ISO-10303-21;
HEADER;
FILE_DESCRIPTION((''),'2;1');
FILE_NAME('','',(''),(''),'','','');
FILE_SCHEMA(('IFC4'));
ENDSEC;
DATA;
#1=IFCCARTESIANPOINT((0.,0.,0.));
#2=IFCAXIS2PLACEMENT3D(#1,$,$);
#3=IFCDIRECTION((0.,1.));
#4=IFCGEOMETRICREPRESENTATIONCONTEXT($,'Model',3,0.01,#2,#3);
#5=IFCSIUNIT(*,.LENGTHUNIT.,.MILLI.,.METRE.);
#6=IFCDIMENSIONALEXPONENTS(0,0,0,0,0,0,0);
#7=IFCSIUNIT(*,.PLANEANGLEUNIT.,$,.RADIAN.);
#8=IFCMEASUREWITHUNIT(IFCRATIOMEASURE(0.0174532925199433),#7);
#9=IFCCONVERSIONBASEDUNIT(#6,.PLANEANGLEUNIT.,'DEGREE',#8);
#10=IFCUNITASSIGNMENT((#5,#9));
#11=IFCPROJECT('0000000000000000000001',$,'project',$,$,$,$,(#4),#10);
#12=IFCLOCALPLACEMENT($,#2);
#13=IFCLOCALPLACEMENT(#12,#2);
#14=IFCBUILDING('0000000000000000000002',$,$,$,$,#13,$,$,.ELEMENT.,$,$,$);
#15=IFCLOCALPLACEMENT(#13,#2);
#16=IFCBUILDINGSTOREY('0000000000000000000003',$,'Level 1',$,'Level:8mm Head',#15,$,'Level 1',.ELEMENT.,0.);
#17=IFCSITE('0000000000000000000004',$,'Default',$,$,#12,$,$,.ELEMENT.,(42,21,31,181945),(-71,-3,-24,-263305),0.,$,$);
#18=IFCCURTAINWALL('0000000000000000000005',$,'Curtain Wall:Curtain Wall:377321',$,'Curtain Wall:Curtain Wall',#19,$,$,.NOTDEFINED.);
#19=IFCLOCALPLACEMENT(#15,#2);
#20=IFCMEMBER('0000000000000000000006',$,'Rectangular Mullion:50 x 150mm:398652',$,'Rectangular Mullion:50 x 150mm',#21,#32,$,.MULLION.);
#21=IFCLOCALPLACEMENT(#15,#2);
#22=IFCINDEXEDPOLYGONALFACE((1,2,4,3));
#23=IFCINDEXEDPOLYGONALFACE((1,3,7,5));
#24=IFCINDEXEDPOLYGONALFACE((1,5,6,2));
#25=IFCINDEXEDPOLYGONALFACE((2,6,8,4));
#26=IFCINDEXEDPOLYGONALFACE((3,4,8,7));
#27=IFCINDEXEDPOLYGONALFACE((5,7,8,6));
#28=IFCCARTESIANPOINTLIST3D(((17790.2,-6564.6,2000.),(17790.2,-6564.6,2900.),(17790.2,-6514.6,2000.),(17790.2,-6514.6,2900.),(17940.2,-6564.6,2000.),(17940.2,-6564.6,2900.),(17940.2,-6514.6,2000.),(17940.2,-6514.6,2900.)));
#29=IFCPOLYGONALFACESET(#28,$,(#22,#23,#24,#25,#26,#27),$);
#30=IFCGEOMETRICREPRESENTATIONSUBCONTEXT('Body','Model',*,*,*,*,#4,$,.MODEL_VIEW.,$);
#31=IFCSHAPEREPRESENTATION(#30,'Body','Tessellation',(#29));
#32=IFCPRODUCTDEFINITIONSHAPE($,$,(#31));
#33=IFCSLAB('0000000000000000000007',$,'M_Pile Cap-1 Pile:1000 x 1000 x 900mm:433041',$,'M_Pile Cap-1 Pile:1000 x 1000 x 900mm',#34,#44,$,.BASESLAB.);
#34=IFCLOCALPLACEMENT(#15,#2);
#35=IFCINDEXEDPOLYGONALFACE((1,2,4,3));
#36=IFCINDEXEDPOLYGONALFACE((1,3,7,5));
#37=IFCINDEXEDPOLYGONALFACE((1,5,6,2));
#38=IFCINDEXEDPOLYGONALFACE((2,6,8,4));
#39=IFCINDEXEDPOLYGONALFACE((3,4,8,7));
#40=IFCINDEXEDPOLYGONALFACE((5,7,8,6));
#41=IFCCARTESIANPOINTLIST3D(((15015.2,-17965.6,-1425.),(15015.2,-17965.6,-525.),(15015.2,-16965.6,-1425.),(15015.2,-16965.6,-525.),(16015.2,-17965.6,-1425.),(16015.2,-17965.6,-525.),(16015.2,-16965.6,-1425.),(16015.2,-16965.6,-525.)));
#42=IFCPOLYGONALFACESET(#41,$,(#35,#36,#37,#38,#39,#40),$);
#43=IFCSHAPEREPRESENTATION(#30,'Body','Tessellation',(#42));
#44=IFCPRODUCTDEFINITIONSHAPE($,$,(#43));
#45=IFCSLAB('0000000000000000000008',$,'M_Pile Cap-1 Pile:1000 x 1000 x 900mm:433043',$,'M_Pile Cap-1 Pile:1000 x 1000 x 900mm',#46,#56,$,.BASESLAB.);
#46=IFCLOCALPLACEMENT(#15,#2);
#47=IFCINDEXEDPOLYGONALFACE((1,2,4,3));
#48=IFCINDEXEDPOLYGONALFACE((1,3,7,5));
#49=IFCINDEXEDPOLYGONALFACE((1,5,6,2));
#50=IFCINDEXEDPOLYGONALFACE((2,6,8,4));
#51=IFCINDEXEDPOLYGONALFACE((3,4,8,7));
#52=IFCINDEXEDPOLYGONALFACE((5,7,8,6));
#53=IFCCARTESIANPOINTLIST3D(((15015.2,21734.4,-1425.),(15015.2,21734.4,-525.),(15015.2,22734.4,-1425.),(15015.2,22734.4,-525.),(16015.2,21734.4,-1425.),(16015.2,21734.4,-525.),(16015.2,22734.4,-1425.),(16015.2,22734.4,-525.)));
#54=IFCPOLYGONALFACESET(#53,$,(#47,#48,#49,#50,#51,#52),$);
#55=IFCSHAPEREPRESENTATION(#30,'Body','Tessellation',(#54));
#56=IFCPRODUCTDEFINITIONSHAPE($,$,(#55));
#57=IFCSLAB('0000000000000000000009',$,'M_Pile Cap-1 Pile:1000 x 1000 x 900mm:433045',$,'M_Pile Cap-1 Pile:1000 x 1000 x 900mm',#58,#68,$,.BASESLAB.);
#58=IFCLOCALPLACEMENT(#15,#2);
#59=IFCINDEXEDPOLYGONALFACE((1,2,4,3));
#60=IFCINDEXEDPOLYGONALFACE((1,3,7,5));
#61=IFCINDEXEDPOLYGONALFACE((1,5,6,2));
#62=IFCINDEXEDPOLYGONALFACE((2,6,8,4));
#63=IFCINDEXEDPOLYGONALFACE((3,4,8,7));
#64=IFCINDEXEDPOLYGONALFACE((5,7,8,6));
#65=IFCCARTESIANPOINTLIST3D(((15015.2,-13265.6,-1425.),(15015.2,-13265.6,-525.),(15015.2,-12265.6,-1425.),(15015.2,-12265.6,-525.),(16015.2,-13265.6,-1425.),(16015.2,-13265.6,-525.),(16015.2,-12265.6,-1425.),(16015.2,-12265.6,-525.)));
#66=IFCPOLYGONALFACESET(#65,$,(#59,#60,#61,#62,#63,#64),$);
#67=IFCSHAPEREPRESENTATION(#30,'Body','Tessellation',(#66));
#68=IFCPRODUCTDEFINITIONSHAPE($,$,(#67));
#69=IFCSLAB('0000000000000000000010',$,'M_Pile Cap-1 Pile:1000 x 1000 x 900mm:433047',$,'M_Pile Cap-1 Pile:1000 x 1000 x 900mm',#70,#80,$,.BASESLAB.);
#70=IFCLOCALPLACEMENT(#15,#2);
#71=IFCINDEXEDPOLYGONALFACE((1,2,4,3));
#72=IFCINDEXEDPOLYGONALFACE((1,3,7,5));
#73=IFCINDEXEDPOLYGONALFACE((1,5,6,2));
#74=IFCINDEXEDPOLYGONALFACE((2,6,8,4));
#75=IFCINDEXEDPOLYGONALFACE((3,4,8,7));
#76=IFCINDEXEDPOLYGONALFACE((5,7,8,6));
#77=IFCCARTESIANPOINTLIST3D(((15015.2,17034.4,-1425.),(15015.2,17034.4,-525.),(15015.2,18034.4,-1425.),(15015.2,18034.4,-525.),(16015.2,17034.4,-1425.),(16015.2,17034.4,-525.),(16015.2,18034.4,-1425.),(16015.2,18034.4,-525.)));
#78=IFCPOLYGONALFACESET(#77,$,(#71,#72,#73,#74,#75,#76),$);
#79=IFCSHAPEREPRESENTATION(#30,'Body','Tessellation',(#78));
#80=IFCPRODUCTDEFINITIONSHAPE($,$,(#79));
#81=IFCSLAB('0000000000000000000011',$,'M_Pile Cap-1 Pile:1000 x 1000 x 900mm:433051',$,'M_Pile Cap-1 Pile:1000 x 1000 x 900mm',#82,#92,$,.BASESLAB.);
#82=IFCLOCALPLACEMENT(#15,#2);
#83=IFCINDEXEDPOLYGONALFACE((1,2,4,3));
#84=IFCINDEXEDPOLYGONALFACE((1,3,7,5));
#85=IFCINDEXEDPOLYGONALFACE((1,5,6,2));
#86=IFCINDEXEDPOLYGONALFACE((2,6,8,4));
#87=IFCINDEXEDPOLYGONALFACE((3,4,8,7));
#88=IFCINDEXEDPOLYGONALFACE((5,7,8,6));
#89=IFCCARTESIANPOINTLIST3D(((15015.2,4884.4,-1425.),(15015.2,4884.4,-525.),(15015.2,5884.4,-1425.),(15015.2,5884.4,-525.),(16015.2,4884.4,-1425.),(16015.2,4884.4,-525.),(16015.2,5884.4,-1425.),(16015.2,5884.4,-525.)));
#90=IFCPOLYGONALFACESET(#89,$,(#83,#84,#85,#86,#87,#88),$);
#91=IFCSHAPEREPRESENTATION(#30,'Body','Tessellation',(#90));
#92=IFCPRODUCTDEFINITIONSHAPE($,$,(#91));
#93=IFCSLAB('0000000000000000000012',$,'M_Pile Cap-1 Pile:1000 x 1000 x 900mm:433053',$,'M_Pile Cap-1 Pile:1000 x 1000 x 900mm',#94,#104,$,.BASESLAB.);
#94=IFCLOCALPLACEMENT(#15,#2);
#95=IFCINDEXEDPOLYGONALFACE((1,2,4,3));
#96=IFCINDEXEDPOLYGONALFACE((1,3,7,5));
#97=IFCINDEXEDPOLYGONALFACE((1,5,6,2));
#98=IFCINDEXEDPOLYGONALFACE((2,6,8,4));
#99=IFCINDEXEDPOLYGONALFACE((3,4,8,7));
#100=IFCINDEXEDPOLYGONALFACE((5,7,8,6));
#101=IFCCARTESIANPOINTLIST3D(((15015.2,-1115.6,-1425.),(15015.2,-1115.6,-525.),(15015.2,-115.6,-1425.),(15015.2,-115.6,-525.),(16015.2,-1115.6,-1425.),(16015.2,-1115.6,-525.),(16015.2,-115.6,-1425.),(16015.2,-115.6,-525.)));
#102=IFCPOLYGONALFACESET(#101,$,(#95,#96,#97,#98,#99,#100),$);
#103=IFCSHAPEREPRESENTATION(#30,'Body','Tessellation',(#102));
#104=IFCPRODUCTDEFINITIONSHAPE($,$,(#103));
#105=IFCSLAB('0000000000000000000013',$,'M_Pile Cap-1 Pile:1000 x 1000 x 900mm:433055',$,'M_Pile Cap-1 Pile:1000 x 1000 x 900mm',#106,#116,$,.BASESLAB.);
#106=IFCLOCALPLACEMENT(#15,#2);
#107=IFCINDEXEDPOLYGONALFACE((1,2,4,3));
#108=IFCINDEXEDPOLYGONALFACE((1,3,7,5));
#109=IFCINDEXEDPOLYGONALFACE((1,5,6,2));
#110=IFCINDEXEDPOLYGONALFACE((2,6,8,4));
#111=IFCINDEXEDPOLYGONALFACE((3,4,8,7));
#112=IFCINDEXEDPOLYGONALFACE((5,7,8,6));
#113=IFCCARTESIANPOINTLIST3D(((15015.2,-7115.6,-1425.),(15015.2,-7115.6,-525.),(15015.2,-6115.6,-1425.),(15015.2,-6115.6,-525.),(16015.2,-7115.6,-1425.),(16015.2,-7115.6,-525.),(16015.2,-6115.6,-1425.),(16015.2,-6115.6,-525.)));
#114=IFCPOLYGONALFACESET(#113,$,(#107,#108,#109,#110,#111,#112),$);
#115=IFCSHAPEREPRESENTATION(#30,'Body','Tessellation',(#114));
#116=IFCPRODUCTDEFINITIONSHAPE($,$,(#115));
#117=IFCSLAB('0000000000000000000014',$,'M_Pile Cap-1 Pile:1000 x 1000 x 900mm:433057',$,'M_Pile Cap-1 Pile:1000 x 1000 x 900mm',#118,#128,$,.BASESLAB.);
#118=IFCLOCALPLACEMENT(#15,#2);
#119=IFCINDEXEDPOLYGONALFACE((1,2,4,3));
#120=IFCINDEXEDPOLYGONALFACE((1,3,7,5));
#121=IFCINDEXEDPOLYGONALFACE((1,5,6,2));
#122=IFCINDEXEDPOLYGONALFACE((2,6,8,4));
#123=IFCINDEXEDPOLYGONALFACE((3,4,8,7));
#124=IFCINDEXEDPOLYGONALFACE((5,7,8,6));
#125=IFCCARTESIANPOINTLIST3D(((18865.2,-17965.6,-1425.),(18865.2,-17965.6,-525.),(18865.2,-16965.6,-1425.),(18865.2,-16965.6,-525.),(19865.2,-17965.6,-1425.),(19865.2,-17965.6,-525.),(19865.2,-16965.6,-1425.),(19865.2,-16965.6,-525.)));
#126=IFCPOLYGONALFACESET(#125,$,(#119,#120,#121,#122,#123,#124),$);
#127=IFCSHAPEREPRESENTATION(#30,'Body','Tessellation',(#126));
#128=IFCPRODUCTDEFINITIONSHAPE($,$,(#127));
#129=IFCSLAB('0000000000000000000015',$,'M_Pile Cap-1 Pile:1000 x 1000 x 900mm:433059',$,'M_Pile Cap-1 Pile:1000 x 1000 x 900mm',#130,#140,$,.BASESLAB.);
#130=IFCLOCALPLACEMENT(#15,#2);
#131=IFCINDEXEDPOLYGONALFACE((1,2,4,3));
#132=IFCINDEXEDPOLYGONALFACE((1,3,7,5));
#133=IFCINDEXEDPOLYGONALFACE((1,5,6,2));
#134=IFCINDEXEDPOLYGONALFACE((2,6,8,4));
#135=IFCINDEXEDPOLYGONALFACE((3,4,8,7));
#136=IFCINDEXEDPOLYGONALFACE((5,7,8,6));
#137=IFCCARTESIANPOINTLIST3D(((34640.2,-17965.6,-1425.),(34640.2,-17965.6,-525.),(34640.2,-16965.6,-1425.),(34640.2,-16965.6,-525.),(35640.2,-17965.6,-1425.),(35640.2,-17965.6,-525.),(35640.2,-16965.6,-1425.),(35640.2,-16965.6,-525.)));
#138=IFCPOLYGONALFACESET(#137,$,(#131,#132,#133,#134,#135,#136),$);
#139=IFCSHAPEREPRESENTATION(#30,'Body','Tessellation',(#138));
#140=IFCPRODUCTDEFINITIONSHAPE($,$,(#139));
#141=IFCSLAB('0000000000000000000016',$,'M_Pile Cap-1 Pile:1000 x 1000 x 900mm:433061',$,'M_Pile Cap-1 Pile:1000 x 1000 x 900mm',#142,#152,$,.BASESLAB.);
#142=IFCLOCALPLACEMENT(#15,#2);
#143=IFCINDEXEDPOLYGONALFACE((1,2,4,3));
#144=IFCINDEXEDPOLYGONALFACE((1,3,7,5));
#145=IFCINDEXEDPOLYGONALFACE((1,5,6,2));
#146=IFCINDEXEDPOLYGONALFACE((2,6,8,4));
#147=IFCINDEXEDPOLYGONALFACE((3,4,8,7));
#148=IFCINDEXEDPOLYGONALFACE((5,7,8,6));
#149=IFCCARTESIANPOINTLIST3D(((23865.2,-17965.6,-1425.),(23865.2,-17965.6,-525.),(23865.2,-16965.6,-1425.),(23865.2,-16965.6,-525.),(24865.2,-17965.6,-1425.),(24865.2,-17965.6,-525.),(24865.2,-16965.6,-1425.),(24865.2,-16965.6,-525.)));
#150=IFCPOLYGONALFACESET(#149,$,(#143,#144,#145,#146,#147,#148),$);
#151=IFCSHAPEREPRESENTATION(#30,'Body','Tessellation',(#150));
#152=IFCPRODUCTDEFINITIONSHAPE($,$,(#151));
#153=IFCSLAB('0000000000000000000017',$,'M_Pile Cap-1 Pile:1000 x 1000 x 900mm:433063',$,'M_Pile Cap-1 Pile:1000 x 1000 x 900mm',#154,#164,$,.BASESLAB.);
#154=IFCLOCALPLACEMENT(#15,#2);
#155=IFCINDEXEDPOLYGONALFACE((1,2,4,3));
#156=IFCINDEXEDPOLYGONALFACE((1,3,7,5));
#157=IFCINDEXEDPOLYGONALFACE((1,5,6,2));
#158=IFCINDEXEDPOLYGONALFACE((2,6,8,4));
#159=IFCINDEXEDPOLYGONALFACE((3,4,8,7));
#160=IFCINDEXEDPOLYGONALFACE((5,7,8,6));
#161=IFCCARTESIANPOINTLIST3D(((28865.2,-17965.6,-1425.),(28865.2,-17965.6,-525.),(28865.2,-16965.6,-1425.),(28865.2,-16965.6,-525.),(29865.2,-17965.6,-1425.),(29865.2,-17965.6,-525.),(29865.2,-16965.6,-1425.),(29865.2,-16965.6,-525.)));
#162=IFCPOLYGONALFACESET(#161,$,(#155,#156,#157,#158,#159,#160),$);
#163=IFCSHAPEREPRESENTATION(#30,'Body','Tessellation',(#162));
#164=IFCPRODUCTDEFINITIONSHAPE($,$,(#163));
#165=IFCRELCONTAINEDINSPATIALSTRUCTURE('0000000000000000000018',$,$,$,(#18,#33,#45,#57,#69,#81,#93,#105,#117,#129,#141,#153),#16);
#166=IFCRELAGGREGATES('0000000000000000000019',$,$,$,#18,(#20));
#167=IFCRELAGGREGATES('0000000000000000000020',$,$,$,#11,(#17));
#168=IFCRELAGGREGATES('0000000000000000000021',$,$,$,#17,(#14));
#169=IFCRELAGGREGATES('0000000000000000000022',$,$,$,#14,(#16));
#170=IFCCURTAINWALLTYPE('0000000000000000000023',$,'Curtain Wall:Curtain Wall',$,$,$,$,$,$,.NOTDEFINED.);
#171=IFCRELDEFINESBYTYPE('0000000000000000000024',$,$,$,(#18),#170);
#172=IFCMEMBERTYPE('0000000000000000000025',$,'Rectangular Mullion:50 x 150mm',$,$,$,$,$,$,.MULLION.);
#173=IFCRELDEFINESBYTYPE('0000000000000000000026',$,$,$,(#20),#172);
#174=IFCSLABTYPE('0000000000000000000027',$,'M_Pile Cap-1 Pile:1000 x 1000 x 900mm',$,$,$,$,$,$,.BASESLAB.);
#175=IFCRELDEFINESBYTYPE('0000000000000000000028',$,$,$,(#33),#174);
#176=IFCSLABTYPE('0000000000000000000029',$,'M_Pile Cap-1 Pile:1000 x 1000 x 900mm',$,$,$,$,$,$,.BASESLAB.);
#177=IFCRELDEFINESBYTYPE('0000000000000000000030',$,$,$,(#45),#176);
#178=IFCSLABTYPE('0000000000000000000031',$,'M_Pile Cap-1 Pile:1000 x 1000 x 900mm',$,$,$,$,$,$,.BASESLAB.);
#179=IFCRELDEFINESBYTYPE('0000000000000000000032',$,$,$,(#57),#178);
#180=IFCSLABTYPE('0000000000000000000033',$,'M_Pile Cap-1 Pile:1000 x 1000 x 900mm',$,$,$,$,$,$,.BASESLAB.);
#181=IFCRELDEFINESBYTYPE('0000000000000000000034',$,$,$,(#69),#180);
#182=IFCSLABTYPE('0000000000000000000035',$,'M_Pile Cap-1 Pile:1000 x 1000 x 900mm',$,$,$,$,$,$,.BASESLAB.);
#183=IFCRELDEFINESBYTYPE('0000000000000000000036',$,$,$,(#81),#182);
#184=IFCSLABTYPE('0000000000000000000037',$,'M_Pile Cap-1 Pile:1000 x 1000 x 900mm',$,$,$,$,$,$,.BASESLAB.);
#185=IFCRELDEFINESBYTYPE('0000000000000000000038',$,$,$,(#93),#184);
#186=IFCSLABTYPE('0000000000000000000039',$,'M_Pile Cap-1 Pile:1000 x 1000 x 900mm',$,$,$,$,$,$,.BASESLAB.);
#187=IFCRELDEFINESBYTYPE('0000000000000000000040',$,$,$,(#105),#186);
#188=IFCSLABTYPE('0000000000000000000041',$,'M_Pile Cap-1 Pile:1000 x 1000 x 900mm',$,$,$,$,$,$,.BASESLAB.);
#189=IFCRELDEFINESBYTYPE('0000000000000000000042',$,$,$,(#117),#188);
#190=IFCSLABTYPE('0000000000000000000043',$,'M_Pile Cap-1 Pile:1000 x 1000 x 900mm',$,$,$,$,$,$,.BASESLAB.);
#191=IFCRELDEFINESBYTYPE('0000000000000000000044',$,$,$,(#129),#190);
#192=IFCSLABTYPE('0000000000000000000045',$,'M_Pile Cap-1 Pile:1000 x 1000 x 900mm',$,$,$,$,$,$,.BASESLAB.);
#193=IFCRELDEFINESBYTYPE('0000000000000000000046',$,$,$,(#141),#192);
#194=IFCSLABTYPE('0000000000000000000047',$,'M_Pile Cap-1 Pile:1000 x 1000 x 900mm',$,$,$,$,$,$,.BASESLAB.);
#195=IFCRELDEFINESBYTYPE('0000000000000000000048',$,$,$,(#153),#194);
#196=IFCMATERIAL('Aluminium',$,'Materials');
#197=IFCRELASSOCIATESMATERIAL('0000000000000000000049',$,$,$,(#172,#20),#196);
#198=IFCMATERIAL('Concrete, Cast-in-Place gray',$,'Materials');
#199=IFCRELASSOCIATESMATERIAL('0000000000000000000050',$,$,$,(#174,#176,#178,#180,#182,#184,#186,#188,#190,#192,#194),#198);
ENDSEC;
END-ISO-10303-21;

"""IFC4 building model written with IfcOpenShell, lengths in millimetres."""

from ifc_helpers import new_model, entity, si_unit, converted_unit, direction, frame, origin, place, context, subcontext, project, spatial, indexed_curve, outline, extrude, source, transform, mapped, material, type_object, type_shapes, element, aggregate, save


model = new_model("IFC4")

# Units and contexts
model_context = context("Model", 3, precision=0.01, world=origin(), true_north=direction((0.0, 1.0)))
body_context = subcontext(model_context, "Body", "Model", "MODEL_VIEW")
ifc_project = project(units=[si_unit("LENGTHUNIT", "METRE", prefix="MILLI"), converted_unit("PLANEANGLEUNIT", "DEGREE", entity("IfcRatioMeasure", 0.0174532925199433), si_unit("PLANEANGLEUNIT", "RADIAN"), dimensions=[0, 0, 0, 0, 0, 0, 0])], contexts=[model_context])

# Site, building, storey
site_placement = place(None, origin())
site = spatial("IfcSite", under=ifc_project, at=site_placement, Name="Default", CompositionType="ELEMENT", RefLatitude=(42, 21, 31, 181945), RefLongitude=(-71, -3, -24, -263305), RefElevation=0.0)
building_placement = place(site_placement, origin())
building = spatial("IfcBuilding", under=site, at=building_placement, CompositionType="ELEMENT")
storey_placement = place(building_placement, origin())
storey = spatial("IfcBuildingStorey", under=building, at=storey_placement, Name="Level 1", ObjectType="Level:8mm Head", LongName="Level 1", CompositionType="ELEMENT", Elevation=0.0)

# Curtain wall, member
curtain_wall_type = type_object("IfcCurtainWallType", Name="Curtain Wall:Curtain Wall", PredefinedType="NOTDEFINED")
curtain_wall_placement = place(storey_placement, origin())
curtain_wall = element("IfcCurtainWall", 1, at=curtain_wall_placement, inside=storey, type_object=curtain_wall_type, Name="Curtain Wall:Curtain Wall:377321", ObjectType="Curtain Wall:Curtain Wall", PredefinedType="NOTDEFINED")
ifc_material_1 = material(Name="Aluminium", Category="Materials")
member_type = type_object("IfcMemberType", Name="Rectangular Mullion:50 x 150mm", PredefinedType="MULLION", material=ifc_material_1)
shared_shape = source(origin(), body_context, "Body", "SweptSolid", [
    extrude(outline(indexed_curve([(-75.0, -25.0), (75.0, -25.0), (75.0, 25.0), (-75.0, 25.0), (-75.0, -25.0)], self_intersect=False)), frame((-25.0, 0.0, -900.0), z_axis=(0.0, 0.0, 1.0), x_axis=(0.0, -1.0, 0.0)), (0.0, 0.0, 1.0), 900.0),
])
type_shapes(member_type, [shared_shape])
member_placement = place(storey_placement, frame((17865.2, -6564.6, 2900.0), z_axis=(0.0, 0.0, 1.0), x_axis=(0.0, -1.0, 0.0)))
member = element("IfcMember", 2, at=member_placement, type_object=member_type, material=ifc_material_1, Name="Rectangular Mullion:50 x 150mm:398652", ObjectType="Rectangular Mullion:50 x 150mm", PredefinedType="MULLION", context=body_context, shape_type="MappedRepresentation", body=[
    mapped(shared_shape, transform((0.0, 0.0, 0.0), scale=1.0)),
])
aggregate(curtain_wall, [member])

# Slabs
ifc_material_2 = material(Name="Concrete, Cast-in-Place gray", Category="Materials")
slab_type_1 = type_object("IfcSlabType", Name="M_Pile Cap-1 Pile:1000 x 1000 x 900mm", PredefinedType="BASESLAB", material=ifc_material_2)
slab_1_placement = place(building_placement, origin())
element("IfcSlab", 3, at=slab_1_placement, inside=storey, type_object=slab_type_1, Name="M_Pile Cap-1 Pile:1000 x 1000 x 900mm:433041", ObjectType="M_Pile Cap-1 Pile:1000 x 1000 x 900mm", PredefinedType="BASESLAB", context=body_context, shape_type="SweptSolid", body=[
    extrude(outline(indexed_curve([(-500.0, -500.0), (500.0, -500.0), (500.0, 500.0), (-500.0, 500.0), (-500.0, -500.0)], self_intersect=False)), frame((15515.2, -17465.6, -1425.0), z_axis=(0.0, 0.0, 1.0), x_axis=(-1.0, 0.0, 0.0)), (0.0, 0.0, 1.0), 900.0),
])
slab_type_2 = type_object("IfcSlabType", Name="M_Pile Cap-1 Pile:1000 x 1000 x 900mm", PredefinedType="BASESLAB", material=ifc_material_2)
slab_2_placement = place(building_placement, origin())
element("IfcSlab", 4, at=slab_2_placement, inside=storey, type_object=slab_type_2, Name="M_Pile Cap-1 Pile:1000 x 1000 x 900mm:433043", ObjectType="M_Pile Cap-1 Pile:1000 x 1000 x 900mm", PredefinedType="BASESLAB", context=body_context, shape_type="SweptSolid", body=[
    extrude(outline(indexed_curve([(-500.0, -500.0), (500.0, -500.0), (500.0, 500.0), (-500.0, 500.0), (-500.0, -500.0)], self_intersect=False)), frame((15515.2, 22234.4, -1425.0), z_axis=(0.0, 0.0, 1.0), x_axis=(-1.0, 0.0, 0.0)), (0.0, 0.0, 1.0), 900.0),
])
slab_type_3 = type_object("IfcSlabType", Name="M_Pile Cap-1 Pile:1000 x 1000 x 900mm", PredefinedType="BASESLAB", material=ifc_material_2)
slab_3_placement = place(building_placement, origin())
element("IfcSlab", 5, at=slab_3_placement, inside=storey, type_object=slab_type_3, Name="M_Pile Cap-1 Pile:1000 x 1000 x 900mm:433045", ObjectType="M_Pile Cap-1 Pile:1000 x 1000 x 900mm", PredefinedType="BASESLAB", context=body_context, shape_type="SweptSolid", body=[
    extrude(outline(indexed_curve([(-500.0, -500.0), (500.0, -500.0), (500.0, 500.0), (-500.0, 500.0), (-500.0, -500.0)], self_intersect=False)), frame((15515.2, -12765.6, -1425.0), z_axis=(0.0, 0.0, 1.0), x_axis=(-1.0, 0.0, 0.0)), (0.0, 0.0, 1.0), 900.0),
])
slab_type_4 = type_object("IfcSlabType", Name="M_Pile Cap-1 Pile:1000 x 1000 x 900mm", PredefinedType="BASESLAB", material=ifc_material_2)
slab_4_placement = place(building_placement, origin())
element("IfcSlab", 6, at=slab_4_placement, inside=storey, type_object=slab_type_4, Name="M_Pile Cap-1 Pile:1000 x 1000 x 900mm:433047", ObjectType="M_Pile Cap-1 Pile:1000 x 1000 x 900mm", PredefinedType="BASESLAB", context=body_context, shape_type="SweptSolid", body=[
    extrude(outline(indexed_curve([(-500.0, -500.0), (500.0, -500.0), (500.0, 500.0), (-500.0, 500.0), (-500.0, -500.0)], self_intersect=False)), frame((15515.2, 17534.4, -1425.0), z_axis=(0.0, 0.0, 1.0), x_axis=(-1.0, 0.0, 0.0)), (0.0, 0.0, 1.0), 900.0),
])
slab_type_5 = type_object("IfcSlabType", Name="M_Pile Cap-1 Pile:1000 x 1000 x 900mm", PredefinedType="BASESLAB", material=ifc_material_2)
slab_5_placement = place(building_placement, origin())
element("IfcSlab", 7, at=slab_5_placement, inside=storey, type_object=slab_type_5, Name="M_Pile Cap-1 Pile:1000 x 1000 x 900mm:433051", ObjectType="M_Pile Cap-1 Pile:1000 x 1000 x 900mm", PredefinedType="BASESLAB", context=body_context, shape_type="SweptSolid", body=[
    extrude(outline(indexed_curve([(-500.0, -500.0), (500.0, -500.0), (500.0, 500.0), (-500.0, 500.0), (-500.0, -500.0)], self_intersect=False)), frame((15515.2, 5384.4, -1425.0), z_axis=(0.0, 0.0, 1.0), x_axis=(-1.0, 0.0, 0.0)), (0.0, 0.0, 1.0), 900.0),
])
slab_type_6 = type_object("IfcSlabType", Name="M_Pile Cap-1 Pile:1000 x 1000 x 900mm", PredefinedType="BASESLAB", material=ifc_material_2)
slab_6_placement = place(building_placement, origin())
element("IfcSlab", 8, at=slab_6_placement, inside=storey, type_object=slab_type_6, Name="M_Pile Cap-1 Pile:1000 x 1000 x 900mm:433053", ObjectType="M_Pile Cap-1 Pile:1000 x 1000 x 900mm", PredefinedType="BASESLAB", context=body_context, shape_type="SweptSolid", body=[
    extrude(outline(indexed_curve([(-500.0, -500.0), (500.0, -500.0), (500.0, 500.0), (-500.0, 500.0), (-500.0, -500.0)], self_intersect=False)), frame((15515.2, -615.6, -1425.0), z_axis=(0.0, 0.0, 1.0), x_axis=(-1.0, 0.0, 0.0)), (0.0, 0.0, 1.0), 900.0),
])
slab_type_7 = type_object("IfcSlabType", Name="M_Pile Cap-1 Pile:1000 x 1000 x 900mm", PredefinedType="BASESLAB", material=ifc_material_2)
slab_7_placement = place(building_placement, origin())
element("IfcSlab", 9, at=slab_7_placement, inside=storey, type_object=slab_type_7, Name="M_Pile Cap-1 Pile:1000 x 1000 x 900mm:433055", ObjectType="M_Pile Cap-1 Pile:1000 x 1000 x 900mm", PredefinedType="BASESLAB", context=body_context, shape_type="SweptSolid", body=[
    extrude(outline(indexed_curve([(-500.0, -500.0), (500.0, -500.0), (500.0, 500.0), (-500.0, 500.0), (-500.0, -500.0)], self_intersect=False)), frame((15515.2, -6615.6, -1425.0), z_axis=(0.0, 0.0, 1.0), x_axis=(-1.0, 0.0, 0.0)), (0.0, 0.0, 1.0), 900.0),
])
slab_type_8 = type_object("IfcSlabType", Name="M_Pile Cap-1 Pile:1000 x 1000 x 900mm", PredefinedType="BASESLAB", material=ifc_material_2)
slab_8_placement = place(building_placement, origin())
element("IfcSlab", 10, at=slab_8_placement, inside=storey, type_object=slab_type_8, Name="M_Pile Cap-1 Pile:1000 x 1000 x 900mm:433057", ObjectType="M_Pile Cap-1 Pile:1000 x 1000 x 900mm", PredefinedType="BASESLAB", context=body_context, shape_type="SweptSolid", body=[
    extrude(outline(indexed_curve([(-500.0, -500.0), (500.0, -500.0), (500.0, 500.0), (-500.0, 500.0), (-500.0, -500.0)], self_intersect=False)), frame((19365.2, -17465.6, -1425.0), z_axis=(0.0, 0.0, 1.0), x_axis=(-1.0, 0.0, 0.0)), (0.0, 0.0, 1.0), 900.0),
])
slab_type_9 = type_object("IfcSlabType", Name="M_Pile Cap-1 Pile:1000 x 1000 x 900mm", PredefinedType="BASESLAB", material=ifc_material_2)
slab_9_placement = place(building_placement, origin())
element("IfcSlab", 11, at=slab_9_placement, inside=storey, type_object=slab_type_9, Name="M_Pile Cap-1 Pile:1000 x 1000 x 900mm:433059", ObjectType="M_Pile Cap-1 Pile:1000 x 1000 x 900mm", PredefinedType="BASESLAB", context=body_context, shape_type="SweptSolid", body=[
    extrude(outline(indexed_curve([(-500.0, -500.0), (500.0, -500.0), (500.0, 500.0), (-500.0, 500.0), (-500.0, -500.0)], self_intersect=False)), frame((35140.2, -17465.6, -1425.0), z_axis=(0.0, 0.0, 1.0), x_axis=(-1.0, 0.0, 0.0)), (0.0, 0.0, 1.0), 900.0),
])
slab_type_10 = type_object("IfcSlabType", Name="M_Pile Cap-1 Pile:1000 x 1000 x 900mm", PredefinedType="BASESLAB", material=ifc_material_2)
slab_10_placement = place(building_placement, origin())
element("IfcSlab", 12, at=slab_10_placement, inside=storey, type_object=slab_type_10, Name="M_Pile Cap-1 Pile:1000 x 1000 x 900mm:433061", ObjectType="M_Pile Cap-1 Pile:1000 x 1000 x 900mm", PredefinedType="BASESLAB", context=body_context, shape_type="SweptSolid", body=[
    extrude(outline(indexed_curve([(-500.0, -500.0), (500.0, -500.0), (500.0, 500.0), (-500.0, 500.0), (-500.0, -500.0)], self_intersect=False)), frame((24365.2, -17465.6, -1425.0), z_axis=(0.0, 0.0, 1.0), x_axis=(-1.0, 0.0, 0.0)), (0.0, 0.0, 1.0), 900.0),
])
slab_type_11 = type_object("IfcSlabType", Name="M_Pile Cap-1 Pile:1000 x 1000 x 900mm", PredefinedType="BASESLAB", material=ifc_material_2)
slab_11_placement = place(building_placement, origin())
element("IfcSlab", 13, at=slab_11_placement, inside=storey, type_object=slab_type_11, Name="M_Pile Cap-1 Pile:1000 x 1000 x 900mm:433063", ObjectType="M_Pile Cap-1 Pile:1000 x 1000 x 900mm", PredefinedType="BASESLAB", context=body_context, shape_type="SweptSolid", body=[
    extrude(outline(indexed_curve([(-500.0, -500.0), (500.0, -500.0), (500.0, 500.0), (-500.0, 500.0), (-500.0, -500.0)], self_intersect=False)), frame((29365.2, -17465.6, -1425.0), z_axis=(0.0, 0.0, 1.0), x_axis=(-1.0, 0.0, 0.0)), (0.0, 0.0, 1.0), 900.0),
])

save(model, "model.ifc")
